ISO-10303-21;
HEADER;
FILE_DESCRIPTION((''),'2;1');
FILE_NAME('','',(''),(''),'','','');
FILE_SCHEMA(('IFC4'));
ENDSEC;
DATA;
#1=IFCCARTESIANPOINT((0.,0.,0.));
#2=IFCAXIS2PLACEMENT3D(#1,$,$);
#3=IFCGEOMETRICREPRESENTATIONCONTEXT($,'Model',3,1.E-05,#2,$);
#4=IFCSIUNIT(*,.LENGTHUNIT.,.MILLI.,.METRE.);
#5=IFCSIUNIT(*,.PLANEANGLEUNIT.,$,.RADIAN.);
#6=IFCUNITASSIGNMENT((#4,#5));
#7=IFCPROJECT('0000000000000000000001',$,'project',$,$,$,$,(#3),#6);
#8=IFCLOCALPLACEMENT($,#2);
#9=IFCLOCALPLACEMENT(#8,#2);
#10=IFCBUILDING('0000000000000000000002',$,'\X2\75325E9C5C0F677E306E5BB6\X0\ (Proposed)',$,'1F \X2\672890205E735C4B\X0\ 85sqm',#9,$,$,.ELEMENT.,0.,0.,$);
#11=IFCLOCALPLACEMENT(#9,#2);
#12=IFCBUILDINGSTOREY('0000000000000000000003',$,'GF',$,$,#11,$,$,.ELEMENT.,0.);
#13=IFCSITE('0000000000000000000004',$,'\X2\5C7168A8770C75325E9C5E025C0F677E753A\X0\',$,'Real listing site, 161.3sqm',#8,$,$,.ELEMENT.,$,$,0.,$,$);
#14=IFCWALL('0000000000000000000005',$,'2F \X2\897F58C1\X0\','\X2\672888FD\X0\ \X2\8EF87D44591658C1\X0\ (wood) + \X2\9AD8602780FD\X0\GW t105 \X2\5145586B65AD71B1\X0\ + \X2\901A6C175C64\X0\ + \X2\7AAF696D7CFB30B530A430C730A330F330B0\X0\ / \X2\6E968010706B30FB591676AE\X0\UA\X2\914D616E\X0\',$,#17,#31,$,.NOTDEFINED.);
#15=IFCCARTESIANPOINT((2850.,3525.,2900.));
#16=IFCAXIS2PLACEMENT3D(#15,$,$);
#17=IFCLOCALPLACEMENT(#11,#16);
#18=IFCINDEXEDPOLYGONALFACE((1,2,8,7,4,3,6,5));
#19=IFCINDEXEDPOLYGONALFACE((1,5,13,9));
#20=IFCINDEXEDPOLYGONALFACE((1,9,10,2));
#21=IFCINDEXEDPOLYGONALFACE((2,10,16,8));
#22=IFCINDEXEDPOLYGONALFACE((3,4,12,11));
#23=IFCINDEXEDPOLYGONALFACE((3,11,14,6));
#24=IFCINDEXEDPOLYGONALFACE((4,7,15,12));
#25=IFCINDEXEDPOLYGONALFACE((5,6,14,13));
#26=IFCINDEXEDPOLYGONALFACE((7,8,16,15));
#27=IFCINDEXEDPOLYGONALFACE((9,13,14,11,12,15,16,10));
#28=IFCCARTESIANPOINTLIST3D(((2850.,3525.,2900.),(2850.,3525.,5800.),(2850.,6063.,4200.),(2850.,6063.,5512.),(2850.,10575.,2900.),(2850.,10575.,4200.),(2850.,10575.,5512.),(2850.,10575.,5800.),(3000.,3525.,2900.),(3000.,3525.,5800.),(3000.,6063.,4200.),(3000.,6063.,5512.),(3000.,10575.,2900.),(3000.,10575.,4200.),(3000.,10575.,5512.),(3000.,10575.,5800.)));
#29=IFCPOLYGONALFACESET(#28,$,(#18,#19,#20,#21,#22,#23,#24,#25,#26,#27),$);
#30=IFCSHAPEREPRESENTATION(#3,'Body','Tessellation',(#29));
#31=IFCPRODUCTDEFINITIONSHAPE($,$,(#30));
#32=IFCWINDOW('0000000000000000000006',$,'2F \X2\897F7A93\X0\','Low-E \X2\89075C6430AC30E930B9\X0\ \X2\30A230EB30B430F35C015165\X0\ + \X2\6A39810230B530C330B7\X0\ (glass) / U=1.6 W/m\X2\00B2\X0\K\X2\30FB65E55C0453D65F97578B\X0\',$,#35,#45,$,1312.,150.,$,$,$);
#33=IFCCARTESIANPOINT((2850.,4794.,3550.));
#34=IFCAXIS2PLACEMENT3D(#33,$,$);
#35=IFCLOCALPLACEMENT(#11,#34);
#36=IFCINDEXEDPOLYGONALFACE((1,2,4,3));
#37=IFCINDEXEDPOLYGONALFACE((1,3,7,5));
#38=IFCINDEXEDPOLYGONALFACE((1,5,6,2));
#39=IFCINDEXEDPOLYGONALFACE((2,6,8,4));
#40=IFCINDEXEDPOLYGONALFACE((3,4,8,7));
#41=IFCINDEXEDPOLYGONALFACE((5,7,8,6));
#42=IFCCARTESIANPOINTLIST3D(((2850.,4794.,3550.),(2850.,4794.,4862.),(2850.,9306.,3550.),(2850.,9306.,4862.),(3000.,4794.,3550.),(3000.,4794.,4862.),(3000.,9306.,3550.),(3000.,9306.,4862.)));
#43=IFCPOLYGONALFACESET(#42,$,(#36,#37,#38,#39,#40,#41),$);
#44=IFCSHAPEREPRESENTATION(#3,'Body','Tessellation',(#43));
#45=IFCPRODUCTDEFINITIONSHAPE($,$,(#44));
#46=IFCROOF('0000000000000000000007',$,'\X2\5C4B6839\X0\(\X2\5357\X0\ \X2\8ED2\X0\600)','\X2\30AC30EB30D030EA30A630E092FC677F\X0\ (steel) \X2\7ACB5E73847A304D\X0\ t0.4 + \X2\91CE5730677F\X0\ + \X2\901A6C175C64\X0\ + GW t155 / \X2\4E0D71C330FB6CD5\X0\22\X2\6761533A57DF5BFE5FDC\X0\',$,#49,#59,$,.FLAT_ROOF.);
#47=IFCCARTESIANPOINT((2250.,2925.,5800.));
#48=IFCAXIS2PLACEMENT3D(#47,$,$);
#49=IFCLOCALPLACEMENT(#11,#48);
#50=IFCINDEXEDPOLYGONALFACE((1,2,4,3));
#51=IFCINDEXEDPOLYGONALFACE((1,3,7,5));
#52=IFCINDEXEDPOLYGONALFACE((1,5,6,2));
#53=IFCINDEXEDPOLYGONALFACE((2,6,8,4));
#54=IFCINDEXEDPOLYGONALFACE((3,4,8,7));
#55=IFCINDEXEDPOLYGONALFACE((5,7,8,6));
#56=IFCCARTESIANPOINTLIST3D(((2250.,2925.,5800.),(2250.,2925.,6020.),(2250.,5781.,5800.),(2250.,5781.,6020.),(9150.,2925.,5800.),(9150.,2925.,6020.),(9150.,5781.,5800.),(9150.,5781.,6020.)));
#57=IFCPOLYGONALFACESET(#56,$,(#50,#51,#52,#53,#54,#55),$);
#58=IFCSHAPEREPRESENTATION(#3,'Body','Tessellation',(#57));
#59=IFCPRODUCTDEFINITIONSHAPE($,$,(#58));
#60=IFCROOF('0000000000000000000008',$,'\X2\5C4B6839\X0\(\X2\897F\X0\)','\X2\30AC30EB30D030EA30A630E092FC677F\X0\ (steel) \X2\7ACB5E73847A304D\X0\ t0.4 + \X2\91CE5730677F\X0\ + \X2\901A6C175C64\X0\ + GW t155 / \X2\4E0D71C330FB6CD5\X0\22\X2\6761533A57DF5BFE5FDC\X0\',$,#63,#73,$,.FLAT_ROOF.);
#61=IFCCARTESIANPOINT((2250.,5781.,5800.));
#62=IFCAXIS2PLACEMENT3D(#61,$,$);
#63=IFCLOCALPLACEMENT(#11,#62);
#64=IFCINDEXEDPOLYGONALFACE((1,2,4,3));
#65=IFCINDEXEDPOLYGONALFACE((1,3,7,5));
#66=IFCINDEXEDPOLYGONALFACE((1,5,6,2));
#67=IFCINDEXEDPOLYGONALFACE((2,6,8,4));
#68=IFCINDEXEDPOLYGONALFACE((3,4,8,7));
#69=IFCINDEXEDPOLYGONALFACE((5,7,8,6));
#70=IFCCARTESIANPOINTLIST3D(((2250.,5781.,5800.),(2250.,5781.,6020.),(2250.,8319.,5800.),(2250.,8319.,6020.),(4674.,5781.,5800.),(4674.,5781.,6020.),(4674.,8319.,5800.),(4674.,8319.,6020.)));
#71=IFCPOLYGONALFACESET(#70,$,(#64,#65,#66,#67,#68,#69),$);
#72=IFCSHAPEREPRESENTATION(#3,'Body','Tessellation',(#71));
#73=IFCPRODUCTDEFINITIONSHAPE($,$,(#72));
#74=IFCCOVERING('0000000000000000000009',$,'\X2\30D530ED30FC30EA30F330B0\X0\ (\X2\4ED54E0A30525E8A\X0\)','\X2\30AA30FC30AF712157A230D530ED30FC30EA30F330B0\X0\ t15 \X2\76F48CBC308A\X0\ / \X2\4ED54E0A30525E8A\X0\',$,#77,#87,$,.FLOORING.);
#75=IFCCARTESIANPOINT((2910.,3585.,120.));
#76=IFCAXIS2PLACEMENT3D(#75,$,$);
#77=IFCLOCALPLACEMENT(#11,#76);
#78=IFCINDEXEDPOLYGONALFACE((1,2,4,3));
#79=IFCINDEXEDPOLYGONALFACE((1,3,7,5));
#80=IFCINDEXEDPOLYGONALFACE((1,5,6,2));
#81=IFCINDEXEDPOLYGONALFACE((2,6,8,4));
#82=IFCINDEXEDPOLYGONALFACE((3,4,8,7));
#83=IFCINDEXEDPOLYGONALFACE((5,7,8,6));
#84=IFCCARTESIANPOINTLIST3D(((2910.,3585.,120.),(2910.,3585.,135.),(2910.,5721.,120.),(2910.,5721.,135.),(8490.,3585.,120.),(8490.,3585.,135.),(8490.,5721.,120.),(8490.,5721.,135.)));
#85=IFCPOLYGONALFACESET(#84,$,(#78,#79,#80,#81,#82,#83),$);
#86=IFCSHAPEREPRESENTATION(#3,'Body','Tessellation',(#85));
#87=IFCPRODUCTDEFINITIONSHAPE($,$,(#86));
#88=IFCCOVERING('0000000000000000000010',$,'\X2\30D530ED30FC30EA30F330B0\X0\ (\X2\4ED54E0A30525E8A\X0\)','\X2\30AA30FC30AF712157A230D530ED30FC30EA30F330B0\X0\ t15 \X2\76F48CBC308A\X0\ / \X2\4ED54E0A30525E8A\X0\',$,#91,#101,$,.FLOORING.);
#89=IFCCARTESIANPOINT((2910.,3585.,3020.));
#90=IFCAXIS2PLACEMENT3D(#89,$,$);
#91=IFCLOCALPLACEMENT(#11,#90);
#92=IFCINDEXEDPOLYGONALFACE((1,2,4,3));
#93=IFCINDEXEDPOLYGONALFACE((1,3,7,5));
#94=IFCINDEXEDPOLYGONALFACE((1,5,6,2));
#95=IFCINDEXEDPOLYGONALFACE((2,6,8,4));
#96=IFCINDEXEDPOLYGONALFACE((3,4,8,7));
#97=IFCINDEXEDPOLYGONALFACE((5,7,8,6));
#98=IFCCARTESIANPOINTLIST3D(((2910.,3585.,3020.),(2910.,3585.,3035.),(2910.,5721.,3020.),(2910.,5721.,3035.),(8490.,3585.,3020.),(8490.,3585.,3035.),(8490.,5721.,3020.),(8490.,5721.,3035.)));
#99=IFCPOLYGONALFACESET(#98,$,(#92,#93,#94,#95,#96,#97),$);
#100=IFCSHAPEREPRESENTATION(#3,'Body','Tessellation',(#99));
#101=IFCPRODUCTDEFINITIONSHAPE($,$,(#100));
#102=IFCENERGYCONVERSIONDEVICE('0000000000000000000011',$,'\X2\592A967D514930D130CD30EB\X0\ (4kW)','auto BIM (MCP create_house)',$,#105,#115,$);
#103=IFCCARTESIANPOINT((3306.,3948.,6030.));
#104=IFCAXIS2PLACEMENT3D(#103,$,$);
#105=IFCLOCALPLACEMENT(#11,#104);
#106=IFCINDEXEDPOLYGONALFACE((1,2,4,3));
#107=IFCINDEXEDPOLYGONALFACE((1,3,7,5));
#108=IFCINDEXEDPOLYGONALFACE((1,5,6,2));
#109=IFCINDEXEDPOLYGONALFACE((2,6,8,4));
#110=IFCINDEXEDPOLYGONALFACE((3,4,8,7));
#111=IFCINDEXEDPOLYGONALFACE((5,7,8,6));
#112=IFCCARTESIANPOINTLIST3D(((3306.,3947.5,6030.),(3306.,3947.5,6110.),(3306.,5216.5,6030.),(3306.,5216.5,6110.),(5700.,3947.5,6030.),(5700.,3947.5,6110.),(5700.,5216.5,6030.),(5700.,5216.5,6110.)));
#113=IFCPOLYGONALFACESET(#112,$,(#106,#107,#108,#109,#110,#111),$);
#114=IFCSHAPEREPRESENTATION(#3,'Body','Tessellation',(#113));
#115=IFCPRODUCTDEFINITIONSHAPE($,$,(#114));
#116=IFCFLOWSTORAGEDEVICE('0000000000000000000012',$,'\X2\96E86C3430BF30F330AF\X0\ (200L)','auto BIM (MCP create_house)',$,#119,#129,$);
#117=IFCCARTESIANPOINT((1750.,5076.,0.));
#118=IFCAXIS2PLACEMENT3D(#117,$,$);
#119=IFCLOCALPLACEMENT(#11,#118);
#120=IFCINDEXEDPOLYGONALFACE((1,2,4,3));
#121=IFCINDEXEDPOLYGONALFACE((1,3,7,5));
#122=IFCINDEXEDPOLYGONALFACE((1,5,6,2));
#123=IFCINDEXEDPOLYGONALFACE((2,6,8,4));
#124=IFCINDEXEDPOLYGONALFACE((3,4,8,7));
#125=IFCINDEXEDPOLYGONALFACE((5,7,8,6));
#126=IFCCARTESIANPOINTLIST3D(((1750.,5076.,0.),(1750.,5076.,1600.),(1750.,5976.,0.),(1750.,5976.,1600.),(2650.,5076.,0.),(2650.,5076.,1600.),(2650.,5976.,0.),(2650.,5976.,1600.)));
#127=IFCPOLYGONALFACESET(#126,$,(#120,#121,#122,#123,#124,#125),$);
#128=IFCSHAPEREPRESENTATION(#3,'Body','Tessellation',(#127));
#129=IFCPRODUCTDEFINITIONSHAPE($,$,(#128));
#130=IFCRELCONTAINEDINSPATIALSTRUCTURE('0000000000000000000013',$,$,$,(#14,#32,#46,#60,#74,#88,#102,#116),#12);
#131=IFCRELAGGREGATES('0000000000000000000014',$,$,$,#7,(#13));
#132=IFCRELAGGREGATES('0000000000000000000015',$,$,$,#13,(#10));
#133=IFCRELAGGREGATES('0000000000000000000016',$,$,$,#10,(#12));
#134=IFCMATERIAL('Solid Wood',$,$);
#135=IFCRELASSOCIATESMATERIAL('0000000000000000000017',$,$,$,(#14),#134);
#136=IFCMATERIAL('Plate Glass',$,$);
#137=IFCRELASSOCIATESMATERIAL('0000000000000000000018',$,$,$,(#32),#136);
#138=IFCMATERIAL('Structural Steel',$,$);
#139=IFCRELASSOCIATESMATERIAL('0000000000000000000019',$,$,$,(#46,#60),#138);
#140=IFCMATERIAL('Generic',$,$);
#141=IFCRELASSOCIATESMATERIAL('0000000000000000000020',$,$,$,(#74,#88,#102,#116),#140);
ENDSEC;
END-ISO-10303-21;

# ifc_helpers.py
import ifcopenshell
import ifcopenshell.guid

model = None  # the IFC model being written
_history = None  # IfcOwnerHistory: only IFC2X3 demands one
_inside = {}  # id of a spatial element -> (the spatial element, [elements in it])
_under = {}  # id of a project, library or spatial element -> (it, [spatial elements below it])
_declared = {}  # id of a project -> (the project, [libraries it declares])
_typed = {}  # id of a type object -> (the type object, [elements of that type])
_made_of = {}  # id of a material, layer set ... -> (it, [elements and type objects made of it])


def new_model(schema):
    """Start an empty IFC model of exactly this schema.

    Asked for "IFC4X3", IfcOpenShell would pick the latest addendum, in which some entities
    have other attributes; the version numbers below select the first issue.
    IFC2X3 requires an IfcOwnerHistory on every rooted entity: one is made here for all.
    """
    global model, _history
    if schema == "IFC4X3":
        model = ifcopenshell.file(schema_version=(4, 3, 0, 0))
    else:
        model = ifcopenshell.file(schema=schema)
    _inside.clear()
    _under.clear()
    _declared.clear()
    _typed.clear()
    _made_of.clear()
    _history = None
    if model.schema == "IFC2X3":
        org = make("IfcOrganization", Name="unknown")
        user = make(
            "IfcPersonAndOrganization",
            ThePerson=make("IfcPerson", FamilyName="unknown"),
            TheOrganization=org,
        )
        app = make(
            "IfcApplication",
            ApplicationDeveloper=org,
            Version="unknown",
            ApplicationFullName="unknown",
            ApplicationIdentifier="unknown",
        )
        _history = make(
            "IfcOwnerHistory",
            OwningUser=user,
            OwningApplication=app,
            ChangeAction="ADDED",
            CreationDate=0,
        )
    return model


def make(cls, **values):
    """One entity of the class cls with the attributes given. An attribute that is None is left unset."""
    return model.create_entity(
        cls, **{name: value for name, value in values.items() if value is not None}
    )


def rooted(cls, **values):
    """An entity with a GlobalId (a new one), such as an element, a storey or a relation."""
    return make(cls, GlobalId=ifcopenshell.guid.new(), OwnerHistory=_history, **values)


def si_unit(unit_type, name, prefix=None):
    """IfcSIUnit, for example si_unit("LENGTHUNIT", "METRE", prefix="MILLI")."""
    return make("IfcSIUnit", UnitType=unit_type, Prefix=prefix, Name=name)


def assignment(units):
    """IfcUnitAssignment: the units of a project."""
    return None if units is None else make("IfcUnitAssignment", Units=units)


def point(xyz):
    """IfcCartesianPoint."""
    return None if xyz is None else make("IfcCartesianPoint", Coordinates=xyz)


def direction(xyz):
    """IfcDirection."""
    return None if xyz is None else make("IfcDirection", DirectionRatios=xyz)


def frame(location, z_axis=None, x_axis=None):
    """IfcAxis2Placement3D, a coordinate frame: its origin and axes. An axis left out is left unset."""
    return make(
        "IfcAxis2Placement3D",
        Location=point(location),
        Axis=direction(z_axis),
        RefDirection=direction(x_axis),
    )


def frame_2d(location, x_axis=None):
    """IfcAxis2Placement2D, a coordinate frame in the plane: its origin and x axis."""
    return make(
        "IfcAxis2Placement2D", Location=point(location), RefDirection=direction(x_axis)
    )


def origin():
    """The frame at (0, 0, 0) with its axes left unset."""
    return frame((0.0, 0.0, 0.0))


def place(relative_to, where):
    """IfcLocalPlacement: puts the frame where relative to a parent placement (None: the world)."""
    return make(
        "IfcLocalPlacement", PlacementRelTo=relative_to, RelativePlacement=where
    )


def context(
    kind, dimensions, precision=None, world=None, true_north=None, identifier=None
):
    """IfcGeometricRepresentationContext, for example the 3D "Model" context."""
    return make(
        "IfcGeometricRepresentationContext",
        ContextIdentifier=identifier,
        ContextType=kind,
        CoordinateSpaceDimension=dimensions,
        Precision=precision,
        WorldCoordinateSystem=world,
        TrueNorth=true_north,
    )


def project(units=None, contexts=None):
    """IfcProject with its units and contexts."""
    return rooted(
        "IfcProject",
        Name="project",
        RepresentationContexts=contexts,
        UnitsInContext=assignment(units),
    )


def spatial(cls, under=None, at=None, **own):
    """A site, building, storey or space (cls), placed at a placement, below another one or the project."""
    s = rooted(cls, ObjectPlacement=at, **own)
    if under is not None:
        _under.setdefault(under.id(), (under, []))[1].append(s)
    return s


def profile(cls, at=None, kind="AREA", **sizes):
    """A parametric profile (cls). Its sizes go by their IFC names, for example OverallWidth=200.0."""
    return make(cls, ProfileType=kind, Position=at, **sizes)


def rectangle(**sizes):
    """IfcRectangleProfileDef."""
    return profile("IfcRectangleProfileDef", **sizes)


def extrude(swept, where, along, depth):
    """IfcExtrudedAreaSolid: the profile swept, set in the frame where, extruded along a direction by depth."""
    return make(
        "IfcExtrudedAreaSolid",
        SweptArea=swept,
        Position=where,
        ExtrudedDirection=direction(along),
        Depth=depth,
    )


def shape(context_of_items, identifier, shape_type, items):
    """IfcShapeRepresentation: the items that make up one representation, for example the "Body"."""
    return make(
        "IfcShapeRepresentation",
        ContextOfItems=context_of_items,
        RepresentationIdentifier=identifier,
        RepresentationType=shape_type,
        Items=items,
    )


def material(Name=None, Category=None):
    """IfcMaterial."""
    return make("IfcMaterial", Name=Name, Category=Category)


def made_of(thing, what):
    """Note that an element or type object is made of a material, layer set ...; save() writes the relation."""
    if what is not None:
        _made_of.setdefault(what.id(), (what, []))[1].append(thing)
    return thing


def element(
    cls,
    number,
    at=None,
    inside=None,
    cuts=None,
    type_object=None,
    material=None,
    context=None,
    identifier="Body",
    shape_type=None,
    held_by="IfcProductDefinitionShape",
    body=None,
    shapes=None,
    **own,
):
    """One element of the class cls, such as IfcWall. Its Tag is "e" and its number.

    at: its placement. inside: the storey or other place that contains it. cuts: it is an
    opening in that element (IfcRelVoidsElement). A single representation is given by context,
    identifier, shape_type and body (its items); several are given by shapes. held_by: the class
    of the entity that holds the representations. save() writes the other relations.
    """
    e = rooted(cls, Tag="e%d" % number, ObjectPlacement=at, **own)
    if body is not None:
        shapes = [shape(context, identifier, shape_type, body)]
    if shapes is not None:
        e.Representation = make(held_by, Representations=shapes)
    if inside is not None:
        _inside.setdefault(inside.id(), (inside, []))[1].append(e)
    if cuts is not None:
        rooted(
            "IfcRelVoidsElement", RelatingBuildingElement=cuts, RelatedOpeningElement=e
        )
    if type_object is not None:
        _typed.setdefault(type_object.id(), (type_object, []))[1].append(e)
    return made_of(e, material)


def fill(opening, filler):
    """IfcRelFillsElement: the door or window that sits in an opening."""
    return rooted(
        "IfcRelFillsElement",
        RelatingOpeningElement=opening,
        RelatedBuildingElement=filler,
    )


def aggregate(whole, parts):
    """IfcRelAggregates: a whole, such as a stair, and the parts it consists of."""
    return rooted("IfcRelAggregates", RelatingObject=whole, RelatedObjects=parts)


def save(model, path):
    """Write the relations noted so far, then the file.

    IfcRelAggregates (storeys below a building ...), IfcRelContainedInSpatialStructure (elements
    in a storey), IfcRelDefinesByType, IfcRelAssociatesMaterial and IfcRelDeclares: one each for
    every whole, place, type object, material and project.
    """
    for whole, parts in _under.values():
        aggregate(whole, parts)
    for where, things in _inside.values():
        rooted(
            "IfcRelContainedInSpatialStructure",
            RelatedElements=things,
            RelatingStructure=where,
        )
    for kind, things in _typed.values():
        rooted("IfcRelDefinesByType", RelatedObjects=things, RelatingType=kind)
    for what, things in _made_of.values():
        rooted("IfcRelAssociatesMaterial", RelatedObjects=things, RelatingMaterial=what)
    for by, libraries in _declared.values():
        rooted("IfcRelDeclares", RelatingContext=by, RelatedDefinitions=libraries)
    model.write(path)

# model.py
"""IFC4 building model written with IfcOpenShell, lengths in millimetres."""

from ifc_helpers import new_model, si_unit, frame, frame_2d, origin, place, context, project, spatial, rectangle, extrude, material, element, fill, save


model = new_model("IFC4")

# Units and contexts
model_context = context("Model", 3, precision=1e-05, world=origin())
ifc_project = project(units=[si_unit("LENGTHUNIT", "METRE", prefix="MILLI"), si_unit("PLANEANGLEUNIT", "RADIAN")], contexts=[model_context])

# Site, building, storey
site_placement = place(None, origin())
site = spatial("IfcSite", under=ifc_project, at=site_placement, Name="山梨県甲府市小松町", ObjectType="Real listing site, 161.3sqm", CompositionType="ELEMENT", RefElevation=0.0)
building_placement = place(site_placement, origin())
building = spatial("IfcBuilding", under=site, at=building_placement, Name="甲府小松の家 (Proposed)", ObjectType="1F 木造平屋 85sqm", CompositionType="ELEMENT", ElevationOfRefHeight=0.0, ElevationOfTerrain=0.0)
storey_placement = place(building_placement, origin())
storey = spatial("IfcBuildingStorey", under=building, at=storey_placement, Name="GF", CompositionType="ELEMENT", Elevation=0.0)

# Shared definitions
ifc_material_1 = material(Name="Solid Wood")
ifc_material_2 = material(Name="Generic")

# Shared definitions
ifc_material_3 = material(Name="Plate Glass")

# Wall, opening, window
wall_1_placement = place(storey_placement, frame((2850.0, 3525.0, 2900.0)))
wall_1 = element("IfcWall", 1, at=wall_1_placement, inside=storey, material=ifc_material_1, Name="2F 西壁", Description="木製 軸組外壁 (wood) + 高性能GW t105 充填断熱 + 通気層 + 窯業系サイディング / 準耐火・外皮UA配慮", PredefinedType="NOTDEFINED", context=model_context, shape_type="SweptSolid", body=[
    extrude(rectangle(XDim=150.0, YDim=7050.0, at=frame_2d((75.0, 3525.0))), frame((2850.0, 3525.0, 2900.0)), (0.0, 0.0, 1.0), 2900.0),
])
opening_1_placement = place(storey_placement, frame((2850.0, 4794.0, 3550.0)))
opening_1 = element("IfcOpeningElement", 2, at=opening_1_placement, cuts=wall_1, PredefinedType="NOTDEFINED", context=model_context, shape_type="SweptSolid", body=[
    extrude(rectangle(XDim=150.0, YDim=4512.0, at=frame_2d((75.0, 2256.0))), frame((2850.0, 4794.0, 3550.0)), (0.0, 0.0, 1.0), 1312.0),
])
window_1_placement = place(storey_placement, frame((2850.0, 4794.0, 3550.0)))
window_1 = element("IfcWindow", 3, at=window_1_placement, inside=storey, material=ifc_material_3, Name="2F 西窓", Description="Low-E 複層ガラス アルゴン封入 + 樹脂サッシ (glass) / U=1.6 W/m²K・日射取得型", OverallHeight=1312.0, OverallWidth=150.0, context=model_context, shape_type="SweptSolid", body=[
    extrude(rectangle(XDim=150.0, YDim=4512.0, at=frame_2d((75.0, 2256.0))), frame((2850.0, 4794.0, 3550.0)), (0.0, 0.0, 1.0), 1312.0),
])
fill(opening_1, window_1)

# Roofs
ifc_material_4 = material(Name="Structural Steel")
roof_1_placement = place(storey_placement, frame((2250.0, 2925.0, 5800.0)))
element("IfcRoof", 4, at=roof_1_placement, inside=storey, material=ifc_material_4, Name="屋根(南 軒600)", Description="ガルバリウム鋼板 (steel) 立平葺き t0.4 + 野地板 + 通気層 + GW t155 / 不燃・法22条区域対応", PredefinedType="FLAT_ROOF", context=model_context, shape_type="SweptSolid", body=[
    extrude(rectangle(XDim=6900.0, YDim=2856.0, at=frame_2d((3450.0, 1428.0))), frame((2250.0, 2925.0, 5800.0)), (0.0, 0.0, 1.0), 220.0),
])
roof_2_placement = place(storey_placement, frame((2250.0, 5781.0, 5800.0)))
element("IfcRoof", 5, at=roof_2_placement, inside=storey, material=ifc_material_4, Name="屋根(西)", Description="ガルバリウム鋼板 (steel) 立平葺き t0.4 + 野地板 + 通気層 + GW t155 / 不燃・法22条区域対応", PredefinedType="FLAT_ROOF", context=model_context, shape_type="SweptSolid", body=[
    extrude(rectangle(XDim=2424.0, YDim=2538.0, at=frame_2d((1212.0, 1269.0))), frame((2250.0, 5781.0, 5800.0)), (0.0, 0.0, 1.0), 220.0),
])

# Coverings
covering_1_placement = place(storey_placement, frame((2910.0, 3585.0, 120.0)))
element("IfcCovering", 6, at=covering_1_placement, inside=storey, material=ifc_material_2, Name="フローリング (仕上げ床)", Description="オーク無垢フローリング t15 直貼り / 仕上げ床", PredefinedType="FLOORING", context=model_context, shape_type="SweptSolid", body=[
    extrude(rectangle(XDim=5580.0, YDim=2136.0, at=frame_2d((2790.0, 1068.0))), frame((2910.0, 3585.0, 120.0)), (0.0, 0.0, 1.0), 15.0),
])
covering_2_placement = place(storey_placement, frame((2910.0, 3585.0, 3020.0)))
element("IfcCovering", 7, at=covering_2_placement, inside=storey, material=ifc_material_2, Name="フローリング (仕上げ床)", Description="オーク無垢フローリング t15 直貼り / 仕上げ床", PredefinedType="FLOORING", context=model_context, shape_type="SweptSolid", body=[
    extrude(rectangle(XDim=5580.0, YDim=2136.0, at=frame_2d((2790.0, 1068.0))), frame((2910.0, 3585.0, 3020.0)), (0.0, 0.0, 1.0), 15.0),
])

# Energy conversion device
energy_conversion_device_placement = place(storey_placement, frame((3306.0, 3948.0, 6030.0)))
element("IfcEnergyConversionDevice", 8, at=energy_conversion_device_placement, inside=storey, material=ifc_material_2, Name="太陽光パネル (4kW)", Description="auto BIM (MCP create_house)", context=model_context, shape_type="SweptSolid", body=[
    extrude(rectangle(XDim=2394.0, YDim=1269.0, at=frame_2d((1197.0, 634.0))), frame((3306.0, 3948.0, 6030.0)), (0.0, 0.0, 1.0), 80.0),
])

# Flow storage device
flow_storage_device_placement = place(storey_placement, frame((1750.0, 5076.0, 0.0)))
element("IfcFlowStorageDevice", 9, at=flow_storage_device_placement, inside=storey, material=ifc_material_2, Name="雨水タンク (200L)", Description="auto BIM (MCP create_house)", context=model_context, shape_type="SweptSolid", body=[
    extrude(rectangle(XDim=900.0, YDim=900.0, at=frame_2d((450.0, 450.0))), frame((1750.0, 5076.0, 0.0)), (0.0, 0.0, 1.0), 1600.0),
])

save(model, "model.ifc")
